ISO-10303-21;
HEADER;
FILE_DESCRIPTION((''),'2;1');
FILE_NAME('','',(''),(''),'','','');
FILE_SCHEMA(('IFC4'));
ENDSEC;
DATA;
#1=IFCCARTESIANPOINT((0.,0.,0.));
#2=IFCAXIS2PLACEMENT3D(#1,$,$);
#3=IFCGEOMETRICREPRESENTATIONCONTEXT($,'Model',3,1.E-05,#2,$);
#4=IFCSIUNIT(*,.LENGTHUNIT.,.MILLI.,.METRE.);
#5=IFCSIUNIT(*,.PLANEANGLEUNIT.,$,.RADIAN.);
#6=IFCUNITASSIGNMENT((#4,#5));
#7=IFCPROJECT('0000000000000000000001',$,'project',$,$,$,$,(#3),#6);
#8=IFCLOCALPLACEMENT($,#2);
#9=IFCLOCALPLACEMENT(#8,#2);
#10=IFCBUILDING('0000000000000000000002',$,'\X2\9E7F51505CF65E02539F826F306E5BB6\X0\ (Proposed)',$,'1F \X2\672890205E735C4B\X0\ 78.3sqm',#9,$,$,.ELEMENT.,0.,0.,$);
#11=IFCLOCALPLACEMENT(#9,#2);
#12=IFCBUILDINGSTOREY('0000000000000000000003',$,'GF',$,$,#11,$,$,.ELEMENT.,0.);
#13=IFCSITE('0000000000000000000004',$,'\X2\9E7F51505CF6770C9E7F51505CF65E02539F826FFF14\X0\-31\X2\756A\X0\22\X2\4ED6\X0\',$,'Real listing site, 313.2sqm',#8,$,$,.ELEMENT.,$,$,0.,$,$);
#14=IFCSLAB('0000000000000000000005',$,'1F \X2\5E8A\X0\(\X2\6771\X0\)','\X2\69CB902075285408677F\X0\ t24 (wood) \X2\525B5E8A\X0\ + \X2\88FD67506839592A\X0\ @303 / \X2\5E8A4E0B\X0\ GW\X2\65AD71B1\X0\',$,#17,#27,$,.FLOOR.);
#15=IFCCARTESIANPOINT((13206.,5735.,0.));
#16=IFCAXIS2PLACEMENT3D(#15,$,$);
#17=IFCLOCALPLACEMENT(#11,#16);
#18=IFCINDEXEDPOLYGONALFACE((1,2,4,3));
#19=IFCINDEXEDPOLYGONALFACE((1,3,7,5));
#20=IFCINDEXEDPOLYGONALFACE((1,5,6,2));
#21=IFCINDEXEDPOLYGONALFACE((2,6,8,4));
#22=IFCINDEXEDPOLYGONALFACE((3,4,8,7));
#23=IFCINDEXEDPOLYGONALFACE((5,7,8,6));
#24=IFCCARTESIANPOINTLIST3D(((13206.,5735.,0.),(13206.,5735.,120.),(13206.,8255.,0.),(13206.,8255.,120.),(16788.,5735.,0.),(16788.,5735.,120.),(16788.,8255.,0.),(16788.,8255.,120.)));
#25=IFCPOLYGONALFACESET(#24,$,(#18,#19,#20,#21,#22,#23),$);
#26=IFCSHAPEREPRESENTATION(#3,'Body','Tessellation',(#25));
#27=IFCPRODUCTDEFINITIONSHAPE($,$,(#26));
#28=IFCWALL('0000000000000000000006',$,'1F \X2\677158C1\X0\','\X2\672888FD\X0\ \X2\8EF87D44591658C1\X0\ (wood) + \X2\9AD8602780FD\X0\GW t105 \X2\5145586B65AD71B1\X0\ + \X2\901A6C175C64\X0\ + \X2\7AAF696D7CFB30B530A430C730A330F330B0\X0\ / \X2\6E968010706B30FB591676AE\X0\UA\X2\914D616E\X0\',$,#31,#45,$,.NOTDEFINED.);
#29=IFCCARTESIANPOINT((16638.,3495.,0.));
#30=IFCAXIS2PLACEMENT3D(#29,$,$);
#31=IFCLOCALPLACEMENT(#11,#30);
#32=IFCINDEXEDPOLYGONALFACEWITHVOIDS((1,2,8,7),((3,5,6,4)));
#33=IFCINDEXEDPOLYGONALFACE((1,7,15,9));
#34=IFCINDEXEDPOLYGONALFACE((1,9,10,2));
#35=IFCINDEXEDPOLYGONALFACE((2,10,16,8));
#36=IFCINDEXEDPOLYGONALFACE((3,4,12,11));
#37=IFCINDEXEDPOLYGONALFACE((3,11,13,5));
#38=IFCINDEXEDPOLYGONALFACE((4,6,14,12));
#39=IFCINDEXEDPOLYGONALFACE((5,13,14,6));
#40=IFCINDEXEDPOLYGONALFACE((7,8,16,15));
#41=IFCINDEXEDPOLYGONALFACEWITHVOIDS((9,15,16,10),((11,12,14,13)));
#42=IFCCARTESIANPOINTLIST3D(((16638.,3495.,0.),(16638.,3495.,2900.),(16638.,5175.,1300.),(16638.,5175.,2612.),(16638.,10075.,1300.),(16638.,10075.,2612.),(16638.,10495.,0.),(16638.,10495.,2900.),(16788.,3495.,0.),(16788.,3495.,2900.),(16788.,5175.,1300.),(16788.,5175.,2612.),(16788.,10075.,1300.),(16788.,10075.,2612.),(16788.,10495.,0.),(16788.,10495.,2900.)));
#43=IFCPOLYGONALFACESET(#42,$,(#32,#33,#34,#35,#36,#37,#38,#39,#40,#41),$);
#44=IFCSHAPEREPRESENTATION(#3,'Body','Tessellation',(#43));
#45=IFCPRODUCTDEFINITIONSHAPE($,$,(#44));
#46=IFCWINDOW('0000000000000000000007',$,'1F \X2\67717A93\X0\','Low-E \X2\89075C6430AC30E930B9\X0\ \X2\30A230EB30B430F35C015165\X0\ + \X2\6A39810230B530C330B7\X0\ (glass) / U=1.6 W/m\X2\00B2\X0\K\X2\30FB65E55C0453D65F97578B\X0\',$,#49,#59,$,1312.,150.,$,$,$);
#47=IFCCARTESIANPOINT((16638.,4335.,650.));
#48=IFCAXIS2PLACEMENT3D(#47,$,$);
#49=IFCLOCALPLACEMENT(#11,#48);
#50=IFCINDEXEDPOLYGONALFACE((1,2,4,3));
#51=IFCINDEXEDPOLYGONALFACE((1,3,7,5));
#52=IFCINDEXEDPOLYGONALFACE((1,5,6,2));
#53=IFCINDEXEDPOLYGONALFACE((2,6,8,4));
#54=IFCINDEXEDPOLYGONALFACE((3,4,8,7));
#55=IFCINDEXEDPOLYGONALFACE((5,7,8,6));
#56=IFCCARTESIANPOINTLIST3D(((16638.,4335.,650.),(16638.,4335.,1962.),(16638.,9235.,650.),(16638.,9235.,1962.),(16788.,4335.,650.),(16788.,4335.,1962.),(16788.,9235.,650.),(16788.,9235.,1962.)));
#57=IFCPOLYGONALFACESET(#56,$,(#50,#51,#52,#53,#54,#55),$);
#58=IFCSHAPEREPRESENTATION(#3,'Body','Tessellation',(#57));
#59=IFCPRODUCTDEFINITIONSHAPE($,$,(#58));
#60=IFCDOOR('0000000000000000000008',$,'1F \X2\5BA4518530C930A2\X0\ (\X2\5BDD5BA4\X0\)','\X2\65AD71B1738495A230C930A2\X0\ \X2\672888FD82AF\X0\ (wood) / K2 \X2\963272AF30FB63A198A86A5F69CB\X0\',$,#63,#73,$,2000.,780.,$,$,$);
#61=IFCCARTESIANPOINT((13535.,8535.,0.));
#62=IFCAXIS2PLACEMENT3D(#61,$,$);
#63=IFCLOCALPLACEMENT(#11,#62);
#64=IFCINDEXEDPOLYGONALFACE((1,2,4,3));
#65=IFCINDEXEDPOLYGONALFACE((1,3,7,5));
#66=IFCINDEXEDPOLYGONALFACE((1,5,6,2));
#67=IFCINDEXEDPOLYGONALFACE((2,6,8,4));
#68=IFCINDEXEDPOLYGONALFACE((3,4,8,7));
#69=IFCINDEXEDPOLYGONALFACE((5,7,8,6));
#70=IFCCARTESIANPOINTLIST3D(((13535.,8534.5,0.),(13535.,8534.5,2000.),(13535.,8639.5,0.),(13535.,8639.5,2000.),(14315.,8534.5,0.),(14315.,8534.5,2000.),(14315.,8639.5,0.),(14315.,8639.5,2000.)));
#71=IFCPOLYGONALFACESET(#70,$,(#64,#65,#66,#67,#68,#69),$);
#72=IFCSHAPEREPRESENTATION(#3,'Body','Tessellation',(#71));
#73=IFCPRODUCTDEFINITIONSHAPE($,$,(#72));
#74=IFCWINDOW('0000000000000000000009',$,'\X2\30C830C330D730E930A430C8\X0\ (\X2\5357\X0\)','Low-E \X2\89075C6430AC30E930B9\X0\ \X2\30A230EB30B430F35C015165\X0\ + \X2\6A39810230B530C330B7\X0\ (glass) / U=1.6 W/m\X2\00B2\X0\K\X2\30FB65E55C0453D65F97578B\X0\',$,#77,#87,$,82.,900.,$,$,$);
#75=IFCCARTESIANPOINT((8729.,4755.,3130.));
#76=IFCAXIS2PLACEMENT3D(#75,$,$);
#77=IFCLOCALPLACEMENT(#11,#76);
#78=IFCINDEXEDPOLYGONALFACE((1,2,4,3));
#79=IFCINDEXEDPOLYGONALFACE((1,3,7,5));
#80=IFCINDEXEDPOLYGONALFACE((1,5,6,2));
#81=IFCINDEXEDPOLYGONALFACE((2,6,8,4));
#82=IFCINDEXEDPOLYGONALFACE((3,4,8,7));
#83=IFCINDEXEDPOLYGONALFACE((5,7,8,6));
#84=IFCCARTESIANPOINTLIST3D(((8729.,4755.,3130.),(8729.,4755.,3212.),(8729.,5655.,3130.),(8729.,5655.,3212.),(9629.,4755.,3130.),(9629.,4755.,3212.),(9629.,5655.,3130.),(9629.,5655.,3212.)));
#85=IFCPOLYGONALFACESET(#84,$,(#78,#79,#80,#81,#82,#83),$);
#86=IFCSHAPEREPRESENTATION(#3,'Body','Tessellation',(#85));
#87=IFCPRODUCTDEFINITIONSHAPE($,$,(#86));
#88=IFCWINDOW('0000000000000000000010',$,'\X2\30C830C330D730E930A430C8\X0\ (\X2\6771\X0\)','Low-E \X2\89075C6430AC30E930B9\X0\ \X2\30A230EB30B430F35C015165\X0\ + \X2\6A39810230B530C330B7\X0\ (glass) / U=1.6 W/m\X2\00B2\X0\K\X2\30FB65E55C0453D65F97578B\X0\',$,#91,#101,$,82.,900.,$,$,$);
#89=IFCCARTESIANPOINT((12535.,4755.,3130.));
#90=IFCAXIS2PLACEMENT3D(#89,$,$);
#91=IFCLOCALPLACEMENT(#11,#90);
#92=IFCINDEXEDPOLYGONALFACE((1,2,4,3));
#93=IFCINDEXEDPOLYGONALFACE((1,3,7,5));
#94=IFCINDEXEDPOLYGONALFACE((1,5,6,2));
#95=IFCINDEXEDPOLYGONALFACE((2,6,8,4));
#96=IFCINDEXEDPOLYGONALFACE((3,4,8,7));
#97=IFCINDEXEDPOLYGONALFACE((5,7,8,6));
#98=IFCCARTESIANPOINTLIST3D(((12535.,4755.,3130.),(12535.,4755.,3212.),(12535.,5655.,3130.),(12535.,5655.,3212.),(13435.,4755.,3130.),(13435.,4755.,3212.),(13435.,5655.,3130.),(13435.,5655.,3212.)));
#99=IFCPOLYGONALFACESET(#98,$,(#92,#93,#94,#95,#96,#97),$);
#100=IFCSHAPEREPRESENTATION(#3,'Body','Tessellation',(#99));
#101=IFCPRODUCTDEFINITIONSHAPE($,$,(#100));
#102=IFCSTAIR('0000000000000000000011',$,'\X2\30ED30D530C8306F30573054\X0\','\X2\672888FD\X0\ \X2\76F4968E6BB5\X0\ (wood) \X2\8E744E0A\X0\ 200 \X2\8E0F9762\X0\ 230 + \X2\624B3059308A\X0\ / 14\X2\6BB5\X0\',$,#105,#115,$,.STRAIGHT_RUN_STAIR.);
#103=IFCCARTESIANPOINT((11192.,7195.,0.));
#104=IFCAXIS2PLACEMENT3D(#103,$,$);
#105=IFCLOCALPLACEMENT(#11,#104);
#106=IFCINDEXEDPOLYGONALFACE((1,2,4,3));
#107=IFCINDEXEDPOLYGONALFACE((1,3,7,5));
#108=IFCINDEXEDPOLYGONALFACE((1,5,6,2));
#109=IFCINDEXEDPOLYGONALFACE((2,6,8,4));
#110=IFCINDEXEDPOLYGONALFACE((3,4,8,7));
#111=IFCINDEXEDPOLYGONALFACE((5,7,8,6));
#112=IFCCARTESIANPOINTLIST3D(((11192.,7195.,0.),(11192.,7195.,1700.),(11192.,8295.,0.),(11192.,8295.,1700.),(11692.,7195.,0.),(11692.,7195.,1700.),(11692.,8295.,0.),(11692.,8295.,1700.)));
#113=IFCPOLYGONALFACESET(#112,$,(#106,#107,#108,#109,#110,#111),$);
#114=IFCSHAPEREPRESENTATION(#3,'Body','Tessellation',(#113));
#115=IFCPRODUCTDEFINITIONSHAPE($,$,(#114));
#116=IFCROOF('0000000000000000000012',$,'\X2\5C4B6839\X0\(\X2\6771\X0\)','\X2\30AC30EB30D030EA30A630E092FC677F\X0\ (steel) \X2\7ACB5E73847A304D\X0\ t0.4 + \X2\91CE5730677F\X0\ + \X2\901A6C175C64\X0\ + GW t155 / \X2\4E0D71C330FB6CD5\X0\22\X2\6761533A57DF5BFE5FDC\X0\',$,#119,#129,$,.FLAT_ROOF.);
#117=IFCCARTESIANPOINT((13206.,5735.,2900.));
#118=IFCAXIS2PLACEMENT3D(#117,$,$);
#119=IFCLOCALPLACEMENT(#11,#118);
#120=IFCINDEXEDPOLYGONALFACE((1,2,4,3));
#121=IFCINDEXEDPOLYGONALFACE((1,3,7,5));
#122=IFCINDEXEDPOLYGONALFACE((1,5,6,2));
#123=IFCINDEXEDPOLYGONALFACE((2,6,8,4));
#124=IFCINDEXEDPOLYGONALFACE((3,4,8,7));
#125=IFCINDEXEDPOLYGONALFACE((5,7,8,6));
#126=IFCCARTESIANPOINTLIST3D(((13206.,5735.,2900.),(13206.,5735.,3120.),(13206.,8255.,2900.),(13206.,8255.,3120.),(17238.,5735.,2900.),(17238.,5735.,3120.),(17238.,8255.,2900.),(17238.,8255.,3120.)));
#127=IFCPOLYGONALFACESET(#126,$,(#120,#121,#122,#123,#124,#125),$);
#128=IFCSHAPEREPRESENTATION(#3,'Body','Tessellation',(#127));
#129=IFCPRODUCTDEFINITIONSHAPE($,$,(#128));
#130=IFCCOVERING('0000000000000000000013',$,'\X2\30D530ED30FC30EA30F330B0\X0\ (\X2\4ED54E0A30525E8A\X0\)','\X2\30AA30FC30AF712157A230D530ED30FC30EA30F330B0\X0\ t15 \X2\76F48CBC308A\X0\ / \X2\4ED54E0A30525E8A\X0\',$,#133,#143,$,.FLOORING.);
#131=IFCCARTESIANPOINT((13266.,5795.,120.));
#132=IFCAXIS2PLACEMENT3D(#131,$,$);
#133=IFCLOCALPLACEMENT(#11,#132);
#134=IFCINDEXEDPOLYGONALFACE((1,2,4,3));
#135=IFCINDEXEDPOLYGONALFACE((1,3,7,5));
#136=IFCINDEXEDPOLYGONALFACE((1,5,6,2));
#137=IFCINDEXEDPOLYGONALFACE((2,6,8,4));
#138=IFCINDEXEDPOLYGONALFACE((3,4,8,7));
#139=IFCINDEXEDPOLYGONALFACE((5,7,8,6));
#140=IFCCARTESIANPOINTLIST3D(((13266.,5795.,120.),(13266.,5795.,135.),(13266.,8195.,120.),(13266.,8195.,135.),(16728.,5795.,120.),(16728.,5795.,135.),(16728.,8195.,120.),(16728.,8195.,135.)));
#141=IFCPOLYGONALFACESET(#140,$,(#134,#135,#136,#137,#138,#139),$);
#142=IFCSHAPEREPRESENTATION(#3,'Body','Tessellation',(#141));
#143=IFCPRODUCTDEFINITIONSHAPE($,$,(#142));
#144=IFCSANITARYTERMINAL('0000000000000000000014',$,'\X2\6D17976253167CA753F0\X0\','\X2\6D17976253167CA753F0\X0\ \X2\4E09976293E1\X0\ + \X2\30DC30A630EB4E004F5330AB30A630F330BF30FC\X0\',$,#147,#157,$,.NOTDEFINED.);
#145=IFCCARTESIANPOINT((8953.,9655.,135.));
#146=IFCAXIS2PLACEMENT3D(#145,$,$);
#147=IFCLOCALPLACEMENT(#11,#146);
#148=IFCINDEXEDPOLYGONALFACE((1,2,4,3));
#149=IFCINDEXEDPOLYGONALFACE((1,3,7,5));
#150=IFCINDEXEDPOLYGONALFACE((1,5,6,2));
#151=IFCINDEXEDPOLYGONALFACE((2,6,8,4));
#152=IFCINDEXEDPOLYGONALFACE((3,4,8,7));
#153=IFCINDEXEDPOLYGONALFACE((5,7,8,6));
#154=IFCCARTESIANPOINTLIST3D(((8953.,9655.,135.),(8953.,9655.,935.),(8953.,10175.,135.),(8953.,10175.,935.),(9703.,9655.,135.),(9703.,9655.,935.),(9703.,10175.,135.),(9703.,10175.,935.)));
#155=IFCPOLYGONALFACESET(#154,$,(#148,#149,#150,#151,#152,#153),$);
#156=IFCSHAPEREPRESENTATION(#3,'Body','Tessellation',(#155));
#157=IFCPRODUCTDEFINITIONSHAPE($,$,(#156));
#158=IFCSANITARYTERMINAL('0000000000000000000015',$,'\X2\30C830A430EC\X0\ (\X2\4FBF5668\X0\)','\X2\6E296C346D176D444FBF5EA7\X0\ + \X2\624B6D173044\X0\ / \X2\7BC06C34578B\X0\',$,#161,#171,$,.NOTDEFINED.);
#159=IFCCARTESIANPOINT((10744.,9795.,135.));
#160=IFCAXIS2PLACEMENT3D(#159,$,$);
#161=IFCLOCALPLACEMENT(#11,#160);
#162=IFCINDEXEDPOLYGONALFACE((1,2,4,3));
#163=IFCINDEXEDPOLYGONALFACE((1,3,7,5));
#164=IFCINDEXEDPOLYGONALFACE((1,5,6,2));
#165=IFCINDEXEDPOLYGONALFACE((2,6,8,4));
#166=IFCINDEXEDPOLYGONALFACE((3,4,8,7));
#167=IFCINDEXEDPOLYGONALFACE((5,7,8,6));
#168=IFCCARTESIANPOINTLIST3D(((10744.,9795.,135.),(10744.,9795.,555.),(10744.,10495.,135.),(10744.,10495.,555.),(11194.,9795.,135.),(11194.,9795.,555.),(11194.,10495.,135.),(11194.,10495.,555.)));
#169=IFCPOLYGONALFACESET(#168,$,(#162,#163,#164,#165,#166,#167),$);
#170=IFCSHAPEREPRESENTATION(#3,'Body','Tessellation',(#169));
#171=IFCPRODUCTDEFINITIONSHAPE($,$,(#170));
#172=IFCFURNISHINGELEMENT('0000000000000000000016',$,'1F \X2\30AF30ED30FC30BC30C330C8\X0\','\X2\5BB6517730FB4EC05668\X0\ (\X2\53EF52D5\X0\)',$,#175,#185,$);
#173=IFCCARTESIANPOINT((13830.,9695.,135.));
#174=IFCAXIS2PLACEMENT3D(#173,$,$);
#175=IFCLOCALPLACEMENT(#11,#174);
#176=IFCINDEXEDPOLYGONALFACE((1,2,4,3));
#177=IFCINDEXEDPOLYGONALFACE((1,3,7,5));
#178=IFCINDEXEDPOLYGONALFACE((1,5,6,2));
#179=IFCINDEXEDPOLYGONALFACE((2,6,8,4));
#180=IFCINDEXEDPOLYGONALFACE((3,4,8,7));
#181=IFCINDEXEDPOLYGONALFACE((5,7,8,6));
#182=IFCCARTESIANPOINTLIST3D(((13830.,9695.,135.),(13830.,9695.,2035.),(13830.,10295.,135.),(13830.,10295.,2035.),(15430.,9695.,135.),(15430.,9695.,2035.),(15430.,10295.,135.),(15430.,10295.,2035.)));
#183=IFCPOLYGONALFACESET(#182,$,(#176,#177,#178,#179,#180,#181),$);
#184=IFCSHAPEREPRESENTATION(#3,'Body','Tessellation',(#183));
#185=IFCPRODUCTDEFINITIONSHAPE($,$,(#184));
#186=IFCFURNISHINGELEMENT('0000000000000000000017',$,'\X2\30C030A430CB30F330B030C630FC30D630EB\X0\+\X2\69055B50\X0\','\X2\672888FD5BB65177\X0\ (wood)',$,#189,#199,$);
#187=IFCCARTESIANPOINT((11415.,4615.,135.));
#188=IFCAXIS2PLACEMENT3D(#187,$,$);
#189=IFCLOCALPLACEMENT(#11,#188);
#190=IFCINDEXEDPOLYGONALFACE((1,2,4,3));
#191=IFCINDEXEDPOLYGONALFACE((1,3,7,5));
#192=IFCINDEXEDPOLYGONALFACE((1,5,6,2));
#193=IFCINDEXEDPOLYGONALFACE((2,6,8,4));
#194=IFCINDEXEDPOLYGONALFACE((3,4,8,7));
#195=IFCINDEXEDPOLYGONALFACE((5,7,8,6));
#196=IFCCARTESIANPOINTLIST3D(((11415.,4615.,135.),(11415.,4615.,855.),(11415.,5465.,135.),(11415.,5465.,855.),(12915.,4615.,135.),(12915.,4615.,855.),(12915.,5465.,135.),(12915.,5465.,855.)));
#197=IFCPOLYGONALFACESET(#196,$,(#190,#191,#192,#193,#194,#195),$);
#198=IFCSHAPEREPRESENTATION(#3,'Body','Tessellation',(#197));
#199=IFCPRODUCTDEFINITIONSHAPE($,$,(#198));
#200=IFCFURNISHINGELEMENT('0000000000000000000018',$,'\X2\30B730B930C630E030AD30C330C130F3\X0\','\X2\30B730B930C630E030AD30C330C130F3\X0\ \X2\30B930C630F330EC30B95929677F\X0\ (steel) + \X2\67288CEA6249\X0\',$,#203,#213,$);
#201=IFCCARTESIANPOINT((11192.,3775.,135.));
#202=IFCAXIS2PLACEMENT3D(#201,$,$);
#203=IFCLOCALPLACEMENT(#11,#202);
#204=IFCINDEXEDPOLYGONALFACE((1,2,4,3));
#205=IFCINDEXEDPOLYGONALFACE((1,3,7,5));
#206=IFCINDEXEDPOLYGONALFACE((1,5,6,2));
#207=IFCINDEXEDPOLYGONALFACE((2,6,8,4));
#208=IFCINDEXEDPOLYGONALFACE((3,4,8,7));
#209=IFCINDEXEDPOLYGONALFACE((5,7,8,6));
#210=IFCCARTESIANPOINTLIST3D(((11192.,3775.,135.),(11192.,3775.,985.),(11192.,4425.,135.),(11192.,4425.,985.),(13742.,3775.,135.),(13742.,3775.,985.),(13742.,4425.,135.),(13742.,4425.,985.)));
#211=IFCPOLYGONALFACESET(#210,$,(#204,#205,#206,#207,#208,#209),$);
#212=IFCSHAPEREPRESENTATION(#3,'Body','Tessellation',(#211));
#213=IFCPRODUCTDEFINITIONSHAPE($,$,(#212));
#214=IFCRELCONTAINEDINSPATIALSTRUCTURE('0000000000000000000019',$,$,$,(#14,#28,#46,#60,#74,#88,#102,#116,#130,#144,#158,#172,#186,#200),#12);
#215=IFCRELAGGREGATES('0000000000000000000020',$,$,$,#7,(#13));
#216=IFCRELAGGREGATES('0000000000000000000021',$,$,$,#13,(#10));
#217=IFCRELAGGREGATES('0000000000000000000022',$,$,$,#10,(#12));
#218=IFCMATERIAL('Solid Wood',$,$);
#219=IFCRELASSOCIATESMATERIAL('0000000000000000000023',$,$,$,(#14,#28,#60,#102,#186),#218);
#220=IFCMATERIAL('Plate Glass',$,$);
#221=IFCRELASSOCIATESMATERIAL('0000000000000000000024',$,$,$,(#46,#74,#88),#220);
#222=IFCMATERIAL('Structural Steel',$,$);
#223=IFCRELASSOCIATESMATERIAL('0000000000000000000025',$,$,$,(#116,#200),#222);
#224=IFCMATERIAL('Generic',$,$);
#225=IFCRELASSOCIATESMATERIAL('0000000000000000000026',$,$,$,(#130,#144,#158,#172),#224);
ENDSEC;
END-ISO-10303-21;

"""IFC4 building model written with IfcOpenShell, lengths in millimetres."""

from ifc_helpers import new_model, si_unit, frame, frame_2d, origin, place, context, project, spatial, rectangle, extrude, material, element, fill, save


model = new_model("IFC4")

# Units and contexts
model_context = context("Model", 3, precision=1e-05, world=origin())
ifc_project = project(units=[si_unit("LENGTHUNIT", "METRE", prefix="MILLI"), si_unit("PLANEANGLEUNIT", "RADIAN")], contexts=[model_context])

# Site, building, storey
site_placement = place(None, origin())
site = spatial("IfcSite", under=ifc_project, at=site_placement, Name="鹿児島県鹿児島市原良４-31番22他", ObjectType="Real listing site, 313.2sqm", CompositionType="ELEMENT", RefElevation=0.0)
building_placement = place(site_placement, origin())
building = spatial("IfcBuilding", under=site, at=building_placement, Name="鹿児島市原良の家 (Proposed)", ObjectType="1F 木造平屋 78.3sqm", CompositionType="ELEMENT", ElevationOfRefHeight=0.0, ElevationOfTerrain=0.0)
storey_placement = place(building_placement, origin())
storey = spatial("IfcBuildingStorey", under=building, at=storey_placement, Name="GF", CompositionType="ELEMENT", Elevation=0.0)

# Slab
ifc_material_1 = material(Name="Solid Wood")
slab_1_placement = place(storey_placement, frame((13206.0, 5735.0, 0.0)))
element("IfcSlab", 1, at=slab_1_placement, inside=storey, material=ifc_material_1, Name="1F 床(東)", Description="構造用合板 t24 (wood) 剛床 + 製材根太 @303 / 床下 GW断熱", PredefinedType="FLOOR", context=model_context, shape_type="SweptSolid", body=[
    extrude(rectangle(XDim=3582.0, YDim=2520.0, at=frame_2d((1791.0, 1260.0))), frame((13206.0, 5735.0, 0.0)), (0.0, 0.0, 1.0), 120.0),
])

# Wall, opening, window
wall_1_placement = place(storey_placement, frame((16638.0, 3495.0, 0.0)))
wall_1 = element("IfcWall", 2, at=wall_1_placement, inside=storey, material=ifc_material_1, Name="1F 東壁", Description="木製 軸組外壁 (wood) + 高性能GW t105 充填断熱 + 通気層 + 窯業系サイディング / 準耐火・外皮UA配慮", PredefinedType="NOTDEFINED", context=model_context, shape_type="SweptSolid", body=[
    extrude(rectangle(XDim=150.0, YDim=7000.0, at=frame_2d((75.0, 3500.0))), frame((16638.0, 3495.0, 0.0)), (0.0, 0.0, 1.0), 2900.0),
])
opening_1_placement = place(storey_placement, frame((16638.0, 4335.0, 650.0)))
opening_1 = element("IfcOpeningElement", 3, at=opening_1_placement, cuts=wall_1, PredefinedType="NOTDEFINED", context=model_context, shape_type="SweptSolid", body=[
    extrude(rectangle(XDim=150.0, YDim=4900.0, at=frame_2d((75.0, 2450.0))), frame((16638.0, 4335.0, 650.0)), (0.0, 0.0, 1.0), 1312.0),
])
ifc_material_2 = material(Name="Plate Glass")
window_1_placement = place(storey_placement, frame((16638.0, 4335.0, 650.0)))
window_1 = element("IfcWindow", 4, at=window_1_placement, inside=storey, material=ifc_material_2, Name="1F 東窓", Description="Low-E 複層ガラス アルゴン封入 + 樹脂サッシ (glass) / U=1.6 W/m²K・日射取得型", OverallHeight=1312.0, OverallWidth=150.0, context=model_context, shape_type="SweptSolid", body=[
    extrude(rectangle(XDim=150.0, YDim=4900.0, at=frame_2d((75.0, 2450.0))), frame((16638.0, 4335.0, 650.0)), (0.0, 0.0, 1.0), 1312.0),
])
fill(opening_1, window_1)

# Door
door_placement = place(storey_placement, frame((13535.0, 8535.0, 0.0)))
element("IfcDoor", 5, at=door_placement, inside=storey, material=ifc_material_1, Name="1F 室内ドア (寝室)", Description="断熱玄関ドア 木製芯 (wood) / K2 防犯・採風機構", OverallHeight=2000.0, OverallWidth=780.0, context=model_context, shape_type="SweptSolid", body=[
    extrude(rectangle(XDim=780.0, YDim=105.0, at=frame_2d((390.0, 52.0))), frame((13535.0, 8535.0, 0.0)), (0.0, 0.0, 1.0), 2000.0),
])

# Windows
window_2_placement = place(storey_placement, frame((8729.0, 4755.0, 3130.0)))
element("IfcWindow", 6, at=window_2_placement, inside=storey, material=ifc_material_2, Name="トップライト (南)", Description="Low-E 複層ガラス アルゴン封入 + 樹脂サッシ (glass) / U=1.6 W/m²K・日射取得型", OverallHeight=82.0, OverallWidth=900.0, context=model_context, shape_type="SweptSolid", body=[
    extrude(rectangle(XDim=900.0, YDim=900.0, at=frame_2d((450.0, 450.0))), frame((8729.0, 4755.0, 3130.0)), (0.0, 0.0, 1.0), 82.0),
])
window_3_placement = place(storey_placement, frame((12535.0, 4755.0, 3130.0)))
element("IfcWindow", 7, at=window_3_placement, inside=storey, material=ifc_material_2, Name="トップライト (東)", Description="Low-E 複層ガラス アルゴン封入 + 樹脂サッシ (glass) / U=1.6 W/m²K・日射取得型", OverallHeight=82.0, OverallWidth=900.0, context=model_context, shape_type="SweptSolid", body=[
    extrude(rectangle(XDim=900.0, YDim=900.0, at=frame_2d((450.0, 450.0))), frame((12535.0, 4755.0, 3130.0)), (0.0, 0.0, 1.0), 82.0),
])

# Stair
stair_placement = place(storey_placement, frame((11192.0, 7195.0, 0.0)))
element("IfcStair", 8, at=stair_placement, inside=storey, material=ifc_material_1, Name="ロフトはしご", Description="木製 直階段 (wood) 蹴上 200 踏面 230 + 手すり / 14段", PredefinedType="STRAIGHT_RUN_STAIR", context=model_context, shape_type="SweptSolid", body=[
    extrude(rectangle(XDim=500.0, YDim=1100.0, at=frame_2d((250.0, 550.0))), frame((11192.0, 7195.0, 0.0)), (0.0, 0.0, 1.0), 1700.0),
])

# Roof
ifc_material_3 = material(Name="Structural Steel")
roof_placement = place(storey_placement, frame((13206.0, 5735.0, 2900.0)))
element("IfcRoof", 9, at=roof_placement, inside=storey, material=ifc_material_3, Name="屋根(東)", Description="ガルバリウム鋼板 (steel) 立平葺き t0.4 + 野地板 + 通気層 + GW t155 / 不燃・法22条区域対応", PredefinedType="FLAT_ROOF", context=model_context, shape_type="SweptSolid", body=[
    extrude(rectangle(XDim=4032.0, YDim=2520.0, at=frame_2d((2016.0, 1260.0))), frame((13206.0, 5735.0, 2900.0)), (0.0, 0.0, 1.0), 220.0),
])

# Covering
ifc_material_4 = material(Name="Generic")
covering_placement = place(storey_placement, frame((13266.0, 5795.0, 120.0)))
element("IfcCovering", 10, at=covering_placement, inside=storey, material=ifc_material_4, Name="フローリング (仕上げ床)", Description="オーク無垢フローリング t15 直貼り / 仕上げ床", PredefinedType="FLOORING", context=model_context, shape_type="SweptSolid", body=[
    extrude(rectangle(XDim=3462.0, YDim=2400.0, at=frame_2d((1731.0, 1200.0))), frame((13266.0, 5795.0, 120.0)), (0.0, 0.0, 1.0), 15.0),
])

# Sanitary terminals
sanitary_terminal_1_placement = place(storey_placement, frame((8953.0, 9655.0, 135.0)))
element("IfcSanitaryTerminal", 11, at=sanitary_terminal_1_placement, inside=storey, material=ifc_material_4, Name="洗面化粧台", Description="洗面化粧台 三面鏡 + ボウル一体カウンター", PredefinedType="NOTDEFINED", context=model_context, shape_type="SweptSolid", body=[
    extrude(rectangle(XDim=750.0, YDim=520.0, at=frame_2d((375.0, 260.0))), frame((8953.0, 9655.0, 135.0)), (0.0, 0.0, 1.0), 800.0),
])
sanitary_terminal_2_placement = place(storey_placement, frame((10744.0, 9795.0, 135.0)))
element("IfcSanitaryTerminal", 12, at=sanitary_terminal_2_placement, inside=storey, material=ifc_material_4, Name="トイレ (便器)", Description="温水洗浄便座 + 手洗い / 節水型", PredefinedType="NOTDEFINED", context=model_context, shape_type="SweptSolid", body=[
    extrude(rectangle(XDim=450.0, YDim=700.0, at=frame_2d((225.0, 350.0))), frame((10744.0, 9795.0, 135.0)), (0.0, 0.0, 1.0), 420.0),
])

# Furnishing elements
furnishing_1_placement = place(storey_placement, frame((13830.0, 9695.0, 135.0)))
element("IfcFurnishingElement", 13, at=furnishing_1_placement, inside=storey, material=ifc_material_4, Name="1F クローゼット", Description="家具・什器 (可動)", context=model_context, shape_type="SweptSolid", body=[
    extrude(rectangle(XDim=1600.0, YDim=600.0, at=frame_2d((800.0, 300.0))), frame((13830.0, 9695.0, 135.0)), (0.0, 0.0, 1.0), 1900.0),
])
furnishing_2_placement = place(storey_placement, frame((11415.0, 4615.0, 135.0)))
element("IfcFurnishingElement", 14, at=furnishing_2_placement, inside=storey, material=ifc_material_1, Name="ダイニングテーブル+椅子", Description="木製家具 (wood)", context=model_context, shape_type="SweptSolid", body=[
    extrude(rectangle(XDim=1500.0, YDim=850.0, at=frame_2d((750.0, 425.0))), frame((11415.0, 4615.0, 135.0)), (0.0, 0.0, 1.0), 720.0),
])
furnishing_3_placement = place(storey_placement, frame((11192.0, 3775.0, 135.0)))
element("IfcFurnishingElement", 15, at=furnishing_3_placement, inside=storey, material=ifc_material_3, Name="システムキッチン", Description="システムキッチン ステンレス天板 (steel) + 木質扉", context=model_context, shape_type="SweptSolid", body=[
    extrude(rectangle(XDim=2550.0, YDim=650.0, at=frame_2d((1275.0, 325.0))), frame((11192.0, 3775.0, 135.0)), (0.0, 0.0, 1.0), 850.0),
])

save(model, "model.ifc")
